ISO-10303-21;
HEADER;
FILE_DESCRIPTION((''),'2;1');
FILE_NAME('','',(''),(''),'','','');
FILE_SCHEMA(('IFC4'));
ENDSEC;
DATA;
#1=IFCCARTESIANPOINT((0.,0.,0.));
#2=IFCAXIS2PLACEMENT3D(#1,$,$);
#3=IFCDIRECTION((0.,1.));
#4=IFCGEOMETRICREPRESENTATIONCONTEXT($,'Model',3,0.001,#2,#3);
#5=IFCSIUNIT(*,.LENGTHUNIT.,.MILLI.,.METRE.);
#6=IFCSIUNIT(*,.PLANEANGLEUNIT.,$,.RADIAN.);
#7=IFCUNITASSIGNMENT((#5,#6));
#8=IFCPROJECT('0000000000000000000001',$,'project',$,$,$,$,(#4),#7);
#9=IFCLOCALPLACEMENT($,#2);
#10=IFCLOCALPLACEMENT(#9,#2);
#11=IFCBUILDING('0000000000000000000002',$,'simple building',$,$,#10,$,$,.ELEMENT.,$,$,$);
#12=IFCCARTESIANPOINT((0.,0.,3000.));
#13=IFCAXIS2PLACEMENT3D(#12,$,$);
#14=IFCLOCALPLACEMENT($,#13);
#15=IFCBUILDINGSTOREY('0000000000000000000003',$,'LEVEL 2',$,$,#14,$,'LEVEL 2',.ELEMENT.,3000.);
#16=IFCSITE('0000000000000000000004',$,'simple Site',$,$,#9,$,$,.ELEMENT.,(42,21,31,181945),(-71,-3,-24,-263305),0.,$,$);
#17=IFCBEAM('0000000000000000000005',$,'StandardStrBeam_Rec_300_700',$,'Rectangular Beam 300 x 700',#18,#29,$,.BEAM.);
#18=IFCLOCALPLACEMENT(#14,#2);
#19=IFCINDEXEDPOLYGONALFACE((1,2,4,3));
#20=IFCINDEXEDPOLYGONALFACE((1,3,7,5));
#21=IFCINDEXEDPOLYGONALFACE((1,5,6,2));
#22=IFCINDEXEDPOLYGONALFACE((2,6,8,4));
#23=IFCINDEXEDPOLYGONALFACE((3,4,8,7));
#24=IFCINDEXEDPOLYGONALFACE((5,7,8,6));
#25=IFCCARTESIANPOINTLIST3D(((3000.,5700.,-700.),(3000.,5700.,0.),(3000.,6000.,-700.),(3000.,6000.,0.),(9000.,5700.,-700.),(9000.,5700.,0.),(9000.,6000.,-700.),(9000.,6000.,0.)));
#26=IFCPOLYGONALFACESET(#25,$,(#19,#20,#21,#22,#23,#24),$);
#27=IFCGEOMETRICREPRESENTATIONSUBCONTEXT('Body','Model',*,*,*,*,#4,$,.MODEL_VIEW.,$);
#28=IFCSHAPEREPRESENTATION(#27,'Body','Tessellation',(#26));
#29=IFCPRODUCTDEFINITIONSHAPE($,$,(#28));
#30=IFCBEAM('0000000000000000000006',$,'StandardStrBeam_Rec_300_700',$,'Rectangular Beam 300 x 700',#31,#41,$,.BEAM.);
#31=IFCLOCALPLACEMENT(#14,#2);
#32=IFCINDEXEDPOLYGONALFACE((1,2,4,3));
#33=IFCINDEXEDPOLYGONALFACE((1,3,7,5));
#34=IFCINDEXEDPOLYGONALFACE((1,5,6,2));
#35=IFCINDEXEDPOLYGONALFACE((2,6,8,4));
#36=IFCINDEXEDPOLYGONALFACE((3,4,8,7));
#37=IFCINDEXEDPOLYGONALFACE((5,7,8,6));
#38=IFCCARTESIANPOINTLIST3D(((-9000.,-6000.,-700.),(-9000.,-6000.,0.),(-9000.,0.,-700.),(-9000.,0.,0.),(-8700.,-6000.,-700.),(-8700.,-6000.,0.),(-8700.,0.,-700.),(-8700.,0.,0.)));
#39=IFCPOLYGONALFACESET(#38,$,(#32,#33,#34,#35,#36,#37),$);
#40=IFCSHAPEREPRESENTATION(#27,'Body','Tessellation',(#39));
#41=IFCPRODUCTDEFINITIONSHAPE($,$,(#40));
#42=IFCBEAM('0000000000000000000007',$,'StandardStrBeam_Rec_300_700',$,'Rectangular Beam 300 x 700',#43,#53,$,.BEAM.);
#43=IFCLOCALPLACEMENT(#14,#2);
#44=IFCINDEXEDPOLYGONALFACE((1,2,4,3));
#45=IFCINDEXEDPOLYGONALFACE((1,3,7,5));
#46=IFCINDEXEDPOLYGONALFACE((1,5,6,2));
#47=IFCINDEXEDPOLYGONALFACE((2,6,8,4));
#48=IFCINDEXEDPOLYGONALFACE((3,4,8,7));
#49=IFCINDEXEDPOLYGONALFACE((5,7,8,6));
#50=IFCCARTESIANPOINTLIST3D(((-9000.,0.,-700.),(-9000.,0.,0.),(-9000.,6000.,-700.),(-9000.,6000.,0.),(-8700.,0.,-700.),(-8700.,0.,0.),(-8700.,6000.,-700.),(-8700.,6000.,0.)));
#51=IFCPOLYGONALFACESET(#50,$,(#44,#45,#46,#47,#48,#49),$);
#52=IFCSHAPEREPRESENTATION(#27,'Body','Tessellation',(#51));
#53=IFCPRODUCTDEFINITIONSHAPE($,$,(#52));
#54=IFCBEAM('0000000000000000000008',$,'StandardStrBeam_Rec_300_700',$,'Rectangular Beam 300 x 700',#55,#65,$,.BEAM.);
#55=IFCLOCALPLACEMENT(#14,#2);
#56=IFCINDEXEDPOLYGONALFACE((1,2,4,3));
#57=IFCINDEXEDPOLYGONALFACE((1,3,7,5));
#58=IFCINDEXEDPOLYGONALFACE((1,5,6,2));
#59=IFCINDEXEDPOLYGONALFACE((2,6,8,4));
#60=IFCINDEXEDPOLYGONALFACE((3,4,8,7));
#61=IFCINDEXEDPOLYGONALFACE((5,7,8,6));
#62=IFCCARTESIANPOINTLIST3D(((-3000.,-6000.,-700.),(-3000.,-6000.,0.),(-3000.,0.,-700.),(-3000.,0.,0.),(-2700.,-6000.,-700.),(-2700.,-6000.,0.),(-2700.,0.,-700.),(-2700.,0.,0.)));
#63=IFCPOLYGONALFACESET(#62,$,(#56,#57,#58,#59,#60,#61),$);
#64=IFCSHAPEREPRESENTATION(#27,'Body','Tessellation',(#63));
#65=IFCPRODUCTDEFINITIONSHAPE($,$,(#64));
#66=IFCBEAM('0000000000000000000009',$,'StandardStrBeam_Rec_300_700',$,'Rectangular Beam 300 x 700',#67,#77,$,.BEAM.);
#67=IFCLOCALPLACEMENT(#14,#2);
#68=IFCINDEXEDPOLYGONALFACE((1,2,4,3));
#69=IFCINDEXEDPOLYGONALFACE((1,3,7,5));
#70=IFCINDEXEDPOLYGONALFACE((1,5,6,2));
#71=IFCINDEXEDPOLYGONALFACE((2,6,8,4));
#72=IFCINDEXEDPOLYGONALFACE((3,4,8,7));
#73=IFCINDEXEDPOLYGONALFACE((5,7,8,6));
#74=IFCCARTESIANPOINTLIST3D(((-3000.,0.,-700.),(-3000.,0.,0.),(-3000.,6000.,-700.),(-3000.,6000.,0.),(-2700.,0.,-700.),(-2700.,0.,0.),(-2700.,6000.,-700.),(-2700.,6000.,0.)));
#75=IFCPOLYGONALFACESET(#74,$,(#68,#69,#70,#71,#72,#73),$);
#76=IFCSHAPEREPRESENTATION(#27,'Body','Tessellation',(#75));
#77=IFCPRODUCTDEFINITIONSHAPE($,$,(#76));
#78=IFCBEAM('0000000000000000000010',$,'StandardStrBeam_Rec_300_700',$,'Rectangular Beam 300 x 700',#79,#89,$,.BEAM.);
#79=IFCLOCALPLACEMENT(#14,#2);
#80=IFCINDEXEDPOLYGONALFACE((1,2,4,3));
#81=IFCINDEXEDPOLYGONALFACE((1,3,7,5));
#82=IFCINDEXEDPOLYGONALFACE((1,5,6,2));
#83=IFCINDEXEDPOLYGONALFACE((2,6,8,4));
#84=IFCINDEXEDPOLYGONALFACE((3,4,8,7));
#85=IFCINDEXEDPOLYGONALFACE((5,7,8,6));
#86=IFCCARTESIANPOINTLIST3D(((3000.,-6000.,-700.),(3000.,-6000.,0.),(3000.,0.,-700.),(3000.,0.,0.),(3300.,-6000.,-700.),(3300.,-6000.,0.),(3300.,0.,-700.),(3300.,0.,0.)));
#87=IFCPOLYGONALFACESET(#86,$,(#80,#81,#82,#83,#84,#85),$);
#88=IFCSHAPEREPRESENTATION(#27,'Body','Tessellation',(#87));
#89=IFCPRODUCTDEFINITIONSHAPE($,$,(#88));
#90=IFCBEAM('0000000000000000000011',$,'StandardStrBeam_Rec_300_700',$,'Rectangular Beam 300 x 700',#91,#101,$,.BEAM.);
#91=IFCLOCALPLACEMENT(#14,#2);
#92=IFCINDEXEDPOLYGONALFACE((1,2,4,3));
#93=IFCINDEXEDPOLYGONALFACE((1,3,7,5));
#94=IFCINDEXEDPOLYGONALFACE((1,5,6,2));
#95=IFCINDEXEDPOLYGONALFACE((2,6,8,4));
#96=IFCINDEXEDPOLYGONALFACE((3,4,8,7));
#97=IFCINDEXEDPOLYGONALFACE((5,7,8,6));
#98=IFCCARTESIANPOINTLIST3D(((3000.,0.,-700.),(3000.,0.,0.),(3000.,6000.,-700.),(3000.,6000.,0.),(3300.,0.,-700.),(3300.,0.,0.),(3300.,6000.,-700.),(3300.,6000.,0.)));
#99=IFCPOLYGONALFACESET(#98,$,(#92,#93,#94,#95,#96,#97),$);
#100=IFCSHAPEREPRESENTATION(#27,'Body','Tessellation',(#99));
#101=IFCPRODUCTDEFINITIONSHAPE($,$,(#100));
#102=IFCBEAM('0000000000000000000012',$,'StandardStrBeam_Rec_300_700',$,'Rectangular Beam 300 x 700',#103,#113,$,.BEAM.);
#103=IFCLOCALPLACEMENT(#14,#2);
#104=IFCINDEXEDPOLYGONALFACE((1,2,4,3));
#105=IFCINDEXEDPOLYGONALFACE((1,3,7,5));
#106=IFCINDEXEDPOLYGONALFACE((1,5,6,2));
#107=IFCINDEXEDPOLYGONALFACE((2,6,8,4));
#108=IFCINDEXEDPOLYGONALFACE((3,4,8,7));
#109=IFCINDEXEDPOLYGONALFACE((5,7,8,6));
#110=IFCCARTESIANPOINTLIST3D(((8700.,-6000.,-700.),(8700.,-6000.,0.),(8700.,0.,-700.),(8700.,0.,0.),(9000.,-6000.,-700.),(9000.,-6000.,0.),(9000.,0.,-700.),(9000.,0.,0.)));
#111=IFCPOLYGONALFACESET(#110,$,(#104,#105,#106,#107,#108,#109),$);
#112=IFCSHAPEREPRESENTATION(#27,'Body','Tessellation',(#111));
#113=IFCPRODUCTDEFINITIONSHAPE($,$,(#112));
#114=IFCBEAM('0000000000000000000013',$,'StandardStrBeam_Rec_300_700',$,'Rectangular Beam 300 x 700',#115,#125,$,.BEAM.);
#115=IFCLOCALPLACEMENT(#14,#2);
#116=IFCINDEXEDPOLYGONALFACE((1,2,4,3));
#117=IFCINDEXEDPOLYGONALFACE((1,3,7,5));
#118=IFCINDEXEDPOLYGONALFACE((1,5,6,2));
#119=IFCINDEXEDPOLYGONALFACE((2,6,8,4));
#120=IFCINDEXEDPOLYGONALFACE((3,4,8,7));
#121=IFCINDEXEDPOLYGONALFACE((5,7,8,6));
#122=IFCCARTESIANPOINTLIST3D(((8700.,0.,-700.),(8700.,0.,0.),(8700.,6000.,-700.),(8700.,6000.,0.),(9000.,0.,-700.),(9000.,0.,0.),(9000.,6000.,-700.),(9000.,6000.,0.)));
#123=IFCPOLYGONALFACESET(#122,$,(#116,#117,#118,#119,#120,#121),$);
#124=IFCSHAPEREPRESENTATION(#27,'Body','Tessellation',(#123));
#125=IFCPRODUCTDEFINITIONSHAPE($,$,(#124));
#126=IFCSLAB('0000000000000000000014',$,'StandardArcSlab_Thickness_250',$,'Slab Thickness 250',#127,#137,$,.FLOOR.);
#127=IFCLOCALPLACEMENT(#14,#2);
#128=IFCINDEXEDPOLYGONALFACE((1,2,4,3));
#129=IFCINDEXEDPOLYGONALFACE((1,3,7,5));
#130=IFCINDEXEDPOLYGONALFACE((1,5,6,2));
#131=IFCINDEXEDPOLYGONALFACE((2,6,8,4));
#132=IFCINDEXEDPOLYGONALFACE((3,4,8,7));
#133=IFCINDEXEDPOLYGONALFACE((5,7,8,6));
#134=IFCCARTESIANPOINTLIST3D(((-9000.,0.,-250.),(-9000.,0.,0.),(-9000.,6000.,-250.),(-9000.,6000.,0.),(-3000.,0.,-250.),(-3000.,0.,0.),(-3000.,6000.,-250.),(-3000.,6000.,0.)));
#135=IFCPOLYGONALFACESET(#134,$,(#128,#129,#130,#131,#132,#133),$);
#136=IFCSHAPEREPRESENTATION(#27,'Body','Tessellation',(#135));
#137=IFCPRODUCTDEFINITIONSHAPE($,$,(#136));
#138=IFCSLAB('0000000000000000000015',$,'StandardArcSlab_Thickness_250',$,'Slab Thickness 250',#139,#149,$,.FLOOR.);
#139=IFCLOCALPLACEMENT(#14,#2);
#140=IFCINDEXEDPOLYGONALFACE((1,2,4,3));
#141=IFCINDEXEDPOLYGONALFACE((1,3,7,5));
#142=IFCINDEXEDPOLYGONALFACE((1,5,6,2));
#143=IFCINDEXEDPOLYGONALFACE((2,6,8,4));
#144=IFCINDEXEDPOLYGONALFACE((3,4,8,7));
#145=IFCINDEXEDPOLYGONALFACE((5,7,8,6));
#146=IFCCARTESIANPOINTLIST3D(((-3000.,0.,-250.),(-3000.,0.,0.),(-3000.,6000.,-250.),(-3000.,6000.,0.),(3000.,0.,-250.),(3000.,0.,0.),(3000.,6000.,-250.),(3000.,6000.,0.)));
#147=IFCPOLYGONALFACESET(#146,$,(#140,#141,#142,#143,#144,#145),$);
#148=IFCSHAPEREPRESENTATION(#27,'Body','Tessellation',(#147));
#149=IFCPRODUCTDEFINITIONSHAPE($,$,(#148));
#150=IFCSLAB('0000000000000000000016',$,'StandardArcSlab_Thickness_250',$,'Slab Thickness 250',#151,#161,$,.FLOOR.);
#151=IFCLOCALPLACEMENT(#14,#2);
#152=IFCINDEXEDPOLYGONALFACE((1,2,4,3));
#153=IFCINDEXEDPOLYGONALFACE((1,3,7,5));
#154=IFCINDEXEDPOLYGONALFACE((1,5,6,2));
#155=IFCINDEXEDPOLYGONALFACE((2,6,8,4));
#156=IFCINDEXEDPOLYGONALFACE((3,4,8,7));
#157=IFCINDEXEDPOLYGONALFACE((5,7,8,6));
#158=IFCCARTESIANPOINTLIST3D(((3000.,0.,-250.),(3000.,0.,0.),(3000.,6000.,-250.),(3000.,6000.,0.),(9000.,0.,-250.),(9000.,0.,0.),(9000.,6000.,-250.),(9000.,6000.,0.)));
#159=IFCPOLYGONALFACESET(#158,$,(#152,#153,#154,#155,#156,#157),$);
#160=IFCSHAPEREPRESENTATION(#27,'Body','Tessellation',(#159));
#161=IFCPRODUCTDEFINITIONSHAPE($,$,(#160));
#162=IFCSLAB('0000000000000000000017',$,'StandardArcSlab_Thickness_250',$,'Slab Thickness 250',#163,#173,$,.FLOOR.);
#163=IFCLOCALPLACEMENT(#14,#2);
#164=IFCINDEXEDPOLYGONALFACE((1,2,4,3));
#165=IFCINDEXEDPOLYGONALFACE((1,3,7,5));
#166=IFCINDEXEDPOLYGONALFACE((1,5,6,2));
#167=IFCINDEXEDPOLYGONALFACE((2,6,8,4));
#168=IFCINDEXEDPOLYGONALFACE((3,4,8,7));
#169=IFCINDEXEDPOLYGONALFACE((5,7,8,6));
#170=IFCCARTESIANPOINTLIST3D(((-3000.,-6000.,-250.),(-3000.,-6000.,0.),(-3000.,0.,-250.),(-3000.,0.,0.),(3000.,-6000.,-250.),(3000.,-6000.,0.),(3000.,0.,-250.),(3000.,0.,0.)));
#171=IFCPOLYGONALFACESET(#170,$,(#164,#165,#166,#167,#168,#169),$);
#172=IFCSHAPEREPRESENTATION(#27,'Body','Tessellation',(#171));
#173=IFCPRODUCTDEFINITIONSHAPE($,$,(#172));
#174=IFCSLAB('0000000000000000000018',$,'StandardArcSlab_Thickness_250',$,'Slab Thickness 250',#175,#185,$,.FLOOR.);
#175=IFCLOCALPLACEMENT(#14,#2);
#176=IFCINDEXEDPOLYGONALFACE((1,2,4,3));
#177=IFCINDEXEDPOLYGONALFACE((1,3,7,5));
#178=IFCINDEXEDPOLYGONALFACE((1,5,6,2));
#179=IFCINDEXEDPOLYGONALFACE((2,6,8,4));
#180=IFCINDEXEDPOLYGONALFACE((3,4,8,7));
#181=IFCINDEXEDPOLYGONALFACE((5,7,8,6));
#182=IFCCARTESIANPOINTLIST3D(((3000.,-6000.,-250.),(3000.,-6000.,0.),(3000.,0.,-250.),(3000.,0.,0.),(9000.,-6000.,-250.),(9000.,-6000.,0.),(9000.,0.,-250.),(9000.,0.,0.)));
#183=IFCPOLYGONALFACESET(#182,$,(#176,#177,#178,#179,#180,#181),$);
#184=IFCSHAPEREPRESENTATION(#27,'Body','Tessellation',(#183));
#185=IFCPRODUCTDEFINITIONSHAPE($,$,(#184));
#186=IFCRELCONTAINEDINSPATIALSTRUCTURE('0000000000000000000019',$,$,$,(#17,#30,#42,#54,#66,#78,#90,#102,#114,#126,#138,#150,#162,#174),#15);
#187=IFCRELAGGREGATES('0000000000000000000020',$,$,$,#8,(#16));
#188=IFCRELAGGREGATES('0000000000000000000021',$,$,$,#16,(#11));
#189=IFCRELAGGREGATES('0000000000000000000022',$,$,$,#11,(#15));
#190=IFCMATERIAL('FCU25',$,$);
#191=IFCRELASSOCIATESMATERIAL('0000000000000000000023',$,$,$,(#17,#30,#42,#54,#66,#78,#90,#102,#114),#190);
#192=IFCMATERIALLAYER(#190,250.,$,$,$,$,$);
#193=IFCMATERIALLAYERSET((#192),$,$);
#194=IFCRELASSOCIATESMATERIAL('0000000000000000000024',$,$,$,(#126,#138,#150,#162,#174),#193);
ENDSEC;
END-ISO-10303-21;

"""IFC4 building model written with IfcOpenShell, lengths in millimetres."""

from ifc_helpers import new_model, si_unit, direction, frame, origin, origin_with_axes, origin_2d_with_axis, place, context, subcontext, project, spatial, polyline, rectangle, outline, extrude, material, layer, layer_set, layer_usage, material_profile, profile_set, profile_usage, element, save


model = new_model("IFC4")

# Units and contexts
model_context = context("Model", 3, precision=0.001, world=origin(), true_north=direction((0.0, 1.0)))
body_context = subcontext(model_context, "Body", "Model", "MODEL_VIEW")
ifc_project = project(units=[si_unit("LENGTHUNIT", "METRE", prefix="MILLI"), si_unit("PLANEANGLEUNIT", "RADIAN")], contexts=[model_context])

# Site, building, storey
site_placement = place(None, origin())
site = spatial("IfcSite", under=ifc_project, at=site_placement, Name="simple Site", CompositionType="ELEMENT", RefLatitude=(42, 21, 31, 181945), RefLongitude=(-71, -3, -24, -263305), RefElevation=0.0)
building_placement = place(site_placement, origin())
building = spatial("IfcBuilding", under=site, at=building_placement, Name="simple building", CompositionType="ELEMENT")
storey_placement = place(None, frame((0.0, 0.0, 3000.0)))
storey = spatial("IfcBuildingStorey", under=building, at=storey_placement, Name="LEVEL 2", LongName="LEVEL 2", CompositionType="ELEMENT", Elevation=3000.0)

# Beams
ifc_material_1 = material(Name="FCU25")
ifc_material_profile_1 = material_profile(ifc_material_1, rectangle(XDim=300.0, YDim=700.0, at=origin_2d_with_axis()))
ifc_profile_set_1 = profile_set([ifc_material_profile_1])
ifc_profile_usage_1 = profile_usage(ifc_profile_set_1, cardinal=9)
ifc_profile_usage_2 = profile_usage(ifc_profile_set_1, cardinal=7)
for number, where, z_axis, x_axis, name in (
    (1, (3000.0, 5850.0, 2650.0), (1.0, 0.0, 0.0), (0.0, -1.0, 0.0), "StandardStrBeam_Rec_300_700"),
    (2, (-8850.0, -6000.0, 2650.0), (0.0, 1.0, 0.0), (1.0, 0.0, 0.0), "StandardStrBeam_Rec_300_700"),
    (3, (-8850.0, 0.0, 2650.0), (0.0, 1.0, 0.0), (1.0, 0.0, 0.0), "StandardStrBeam_Rec_300_700"),
    (4, (-2850.0, -6000.0, 2650.0), (0.0, 1.0, 0.0), (1.0, 0.0, 0.0), "StandardStrBeam_Rec_300_700"),
    (5, (-2850.0, 0.0, 2650.0), (0.0, 1.0, 0.0), (1.0, 0.0, 0.0), "StandardStrBeam_Rec_300_700"),
    (6, (3150.0, -6000.0, 2650.0), (0.0, 1.0, 0.0), (1.0, 0.0, 0.0), "StandardStrBeam_Rec_300_700"),
    (7, (3150.0, 0.0, 2650.0), (0.0, 1.0, 0.0), (1.0, 0.0, 0.0), "StandardStrBeam_Rec_300_700"),
):
    element("IfcBeam", number, at=place(None, frame(where, z_axis=z_axis, x_axis=x_axis)), inside=storey, material=ifc_profile_usage_2, Name=name, ObjectType="Rectangular Beam 300 x 700", PredefinedType="BEAM", context=body_context, shape_type="SweptSolid", body=[
        extrude(rectangle(XDim=300.0, YDim=700.0, at=origin_2d_with_axis()), origin_with_axes(), (0.0, 0.0, 1.0), 6000.0),
    ])
for number, where, z_axis, x_axis, name in (
    (8, (8850.0, -6000.0, 2650.0), (0.0, 1.0, 0.0), (1.0, 0.0, 0.0), "StandardStrBeam_Rec_300_700"),
    (9, (8850.0, 0.0, 2650.0), (0.0, 1.0, 0.0), (1.0, 0.0, 0.0), "StandardStrBeam_Rec_300_700"),
):
    element("IfcBeam", number, at=place(None, frame(where, z_axis=z_axis, x_axis=x_axis)), inside=storey, material=ifc_profile_usage_1, Name=name, ObjectType="Rectangular Beam 300 x 700", PredefinedType="BEAM", context=body_context, shape_type="SweptSolid", body=[
        extrude(rectangle(XDim=300.0, YDim=700.0, at=origin_2d_with_axis()), origin_with_axes(), (0.0, 0.0, 1.0), 6000.0),
    ])

# Slabs
ifc_layer = layer(ifc_material_1, 250.0)
ifc_layer_set = layer_set([ifc_layer])
ifc_layer_usage = layer_usage(ifc_layer_set, "AXIS3", "POSITIVE", -250.0)
for number, where, z_axis, x_axis, name in (
    (10, (-9000.0, 0.0, 2750.0), (0.0, 0.0, 1.0), (1.0, 0.0, 0.0), "StandardArcSlab_Thickness_250"),
    (11, (-3000.0, 0.0, 2750.0), (0.0, 0.0, 1.0), (1.0, 0.0, 0.0), "StandardArcSlab_Thickness_250"),
    (12, (3000.0, 0.0, 2750.0), (0.0, 0.0, 1.0), (1.0, 0.0, 0.0), "StandardArcSlab_Thickness_250"),
    (13, (-3000.0, -6000.0, 2750.0), (0.0, 0.0, 1.0), (1.0, 0.0, 0.0), "StandardArcSlab_Thickness_250"),
    (14, (3000.0, -6000.0, 2750.0), (0.0, 0.0, 1.0), (1.0, 0.0, 0.0), "StandardArcSlab_Thickness_250"),
):
    element("IfcSlab", number, at=place(None, frame(where, z_axis=z_axis, x_axis=x_axis)), inside=storey, material=ifc_layer_usage, Name=name, ObjectType="Slab Thickness 250", PredefinedType="FLOOR", context=body_context, shape_type="SweptSolid", body=[
        extrude(outline(polyline([(0.0, 0.0), (6000.0, 0.0), (6000.0, 6000.0), (0.0, 6000.0), (0.0, 0.0)])), origin_with_axes(), (0.0, 0.0, 1.0), 250.0),
    ])

save(model, "model.ifc")
